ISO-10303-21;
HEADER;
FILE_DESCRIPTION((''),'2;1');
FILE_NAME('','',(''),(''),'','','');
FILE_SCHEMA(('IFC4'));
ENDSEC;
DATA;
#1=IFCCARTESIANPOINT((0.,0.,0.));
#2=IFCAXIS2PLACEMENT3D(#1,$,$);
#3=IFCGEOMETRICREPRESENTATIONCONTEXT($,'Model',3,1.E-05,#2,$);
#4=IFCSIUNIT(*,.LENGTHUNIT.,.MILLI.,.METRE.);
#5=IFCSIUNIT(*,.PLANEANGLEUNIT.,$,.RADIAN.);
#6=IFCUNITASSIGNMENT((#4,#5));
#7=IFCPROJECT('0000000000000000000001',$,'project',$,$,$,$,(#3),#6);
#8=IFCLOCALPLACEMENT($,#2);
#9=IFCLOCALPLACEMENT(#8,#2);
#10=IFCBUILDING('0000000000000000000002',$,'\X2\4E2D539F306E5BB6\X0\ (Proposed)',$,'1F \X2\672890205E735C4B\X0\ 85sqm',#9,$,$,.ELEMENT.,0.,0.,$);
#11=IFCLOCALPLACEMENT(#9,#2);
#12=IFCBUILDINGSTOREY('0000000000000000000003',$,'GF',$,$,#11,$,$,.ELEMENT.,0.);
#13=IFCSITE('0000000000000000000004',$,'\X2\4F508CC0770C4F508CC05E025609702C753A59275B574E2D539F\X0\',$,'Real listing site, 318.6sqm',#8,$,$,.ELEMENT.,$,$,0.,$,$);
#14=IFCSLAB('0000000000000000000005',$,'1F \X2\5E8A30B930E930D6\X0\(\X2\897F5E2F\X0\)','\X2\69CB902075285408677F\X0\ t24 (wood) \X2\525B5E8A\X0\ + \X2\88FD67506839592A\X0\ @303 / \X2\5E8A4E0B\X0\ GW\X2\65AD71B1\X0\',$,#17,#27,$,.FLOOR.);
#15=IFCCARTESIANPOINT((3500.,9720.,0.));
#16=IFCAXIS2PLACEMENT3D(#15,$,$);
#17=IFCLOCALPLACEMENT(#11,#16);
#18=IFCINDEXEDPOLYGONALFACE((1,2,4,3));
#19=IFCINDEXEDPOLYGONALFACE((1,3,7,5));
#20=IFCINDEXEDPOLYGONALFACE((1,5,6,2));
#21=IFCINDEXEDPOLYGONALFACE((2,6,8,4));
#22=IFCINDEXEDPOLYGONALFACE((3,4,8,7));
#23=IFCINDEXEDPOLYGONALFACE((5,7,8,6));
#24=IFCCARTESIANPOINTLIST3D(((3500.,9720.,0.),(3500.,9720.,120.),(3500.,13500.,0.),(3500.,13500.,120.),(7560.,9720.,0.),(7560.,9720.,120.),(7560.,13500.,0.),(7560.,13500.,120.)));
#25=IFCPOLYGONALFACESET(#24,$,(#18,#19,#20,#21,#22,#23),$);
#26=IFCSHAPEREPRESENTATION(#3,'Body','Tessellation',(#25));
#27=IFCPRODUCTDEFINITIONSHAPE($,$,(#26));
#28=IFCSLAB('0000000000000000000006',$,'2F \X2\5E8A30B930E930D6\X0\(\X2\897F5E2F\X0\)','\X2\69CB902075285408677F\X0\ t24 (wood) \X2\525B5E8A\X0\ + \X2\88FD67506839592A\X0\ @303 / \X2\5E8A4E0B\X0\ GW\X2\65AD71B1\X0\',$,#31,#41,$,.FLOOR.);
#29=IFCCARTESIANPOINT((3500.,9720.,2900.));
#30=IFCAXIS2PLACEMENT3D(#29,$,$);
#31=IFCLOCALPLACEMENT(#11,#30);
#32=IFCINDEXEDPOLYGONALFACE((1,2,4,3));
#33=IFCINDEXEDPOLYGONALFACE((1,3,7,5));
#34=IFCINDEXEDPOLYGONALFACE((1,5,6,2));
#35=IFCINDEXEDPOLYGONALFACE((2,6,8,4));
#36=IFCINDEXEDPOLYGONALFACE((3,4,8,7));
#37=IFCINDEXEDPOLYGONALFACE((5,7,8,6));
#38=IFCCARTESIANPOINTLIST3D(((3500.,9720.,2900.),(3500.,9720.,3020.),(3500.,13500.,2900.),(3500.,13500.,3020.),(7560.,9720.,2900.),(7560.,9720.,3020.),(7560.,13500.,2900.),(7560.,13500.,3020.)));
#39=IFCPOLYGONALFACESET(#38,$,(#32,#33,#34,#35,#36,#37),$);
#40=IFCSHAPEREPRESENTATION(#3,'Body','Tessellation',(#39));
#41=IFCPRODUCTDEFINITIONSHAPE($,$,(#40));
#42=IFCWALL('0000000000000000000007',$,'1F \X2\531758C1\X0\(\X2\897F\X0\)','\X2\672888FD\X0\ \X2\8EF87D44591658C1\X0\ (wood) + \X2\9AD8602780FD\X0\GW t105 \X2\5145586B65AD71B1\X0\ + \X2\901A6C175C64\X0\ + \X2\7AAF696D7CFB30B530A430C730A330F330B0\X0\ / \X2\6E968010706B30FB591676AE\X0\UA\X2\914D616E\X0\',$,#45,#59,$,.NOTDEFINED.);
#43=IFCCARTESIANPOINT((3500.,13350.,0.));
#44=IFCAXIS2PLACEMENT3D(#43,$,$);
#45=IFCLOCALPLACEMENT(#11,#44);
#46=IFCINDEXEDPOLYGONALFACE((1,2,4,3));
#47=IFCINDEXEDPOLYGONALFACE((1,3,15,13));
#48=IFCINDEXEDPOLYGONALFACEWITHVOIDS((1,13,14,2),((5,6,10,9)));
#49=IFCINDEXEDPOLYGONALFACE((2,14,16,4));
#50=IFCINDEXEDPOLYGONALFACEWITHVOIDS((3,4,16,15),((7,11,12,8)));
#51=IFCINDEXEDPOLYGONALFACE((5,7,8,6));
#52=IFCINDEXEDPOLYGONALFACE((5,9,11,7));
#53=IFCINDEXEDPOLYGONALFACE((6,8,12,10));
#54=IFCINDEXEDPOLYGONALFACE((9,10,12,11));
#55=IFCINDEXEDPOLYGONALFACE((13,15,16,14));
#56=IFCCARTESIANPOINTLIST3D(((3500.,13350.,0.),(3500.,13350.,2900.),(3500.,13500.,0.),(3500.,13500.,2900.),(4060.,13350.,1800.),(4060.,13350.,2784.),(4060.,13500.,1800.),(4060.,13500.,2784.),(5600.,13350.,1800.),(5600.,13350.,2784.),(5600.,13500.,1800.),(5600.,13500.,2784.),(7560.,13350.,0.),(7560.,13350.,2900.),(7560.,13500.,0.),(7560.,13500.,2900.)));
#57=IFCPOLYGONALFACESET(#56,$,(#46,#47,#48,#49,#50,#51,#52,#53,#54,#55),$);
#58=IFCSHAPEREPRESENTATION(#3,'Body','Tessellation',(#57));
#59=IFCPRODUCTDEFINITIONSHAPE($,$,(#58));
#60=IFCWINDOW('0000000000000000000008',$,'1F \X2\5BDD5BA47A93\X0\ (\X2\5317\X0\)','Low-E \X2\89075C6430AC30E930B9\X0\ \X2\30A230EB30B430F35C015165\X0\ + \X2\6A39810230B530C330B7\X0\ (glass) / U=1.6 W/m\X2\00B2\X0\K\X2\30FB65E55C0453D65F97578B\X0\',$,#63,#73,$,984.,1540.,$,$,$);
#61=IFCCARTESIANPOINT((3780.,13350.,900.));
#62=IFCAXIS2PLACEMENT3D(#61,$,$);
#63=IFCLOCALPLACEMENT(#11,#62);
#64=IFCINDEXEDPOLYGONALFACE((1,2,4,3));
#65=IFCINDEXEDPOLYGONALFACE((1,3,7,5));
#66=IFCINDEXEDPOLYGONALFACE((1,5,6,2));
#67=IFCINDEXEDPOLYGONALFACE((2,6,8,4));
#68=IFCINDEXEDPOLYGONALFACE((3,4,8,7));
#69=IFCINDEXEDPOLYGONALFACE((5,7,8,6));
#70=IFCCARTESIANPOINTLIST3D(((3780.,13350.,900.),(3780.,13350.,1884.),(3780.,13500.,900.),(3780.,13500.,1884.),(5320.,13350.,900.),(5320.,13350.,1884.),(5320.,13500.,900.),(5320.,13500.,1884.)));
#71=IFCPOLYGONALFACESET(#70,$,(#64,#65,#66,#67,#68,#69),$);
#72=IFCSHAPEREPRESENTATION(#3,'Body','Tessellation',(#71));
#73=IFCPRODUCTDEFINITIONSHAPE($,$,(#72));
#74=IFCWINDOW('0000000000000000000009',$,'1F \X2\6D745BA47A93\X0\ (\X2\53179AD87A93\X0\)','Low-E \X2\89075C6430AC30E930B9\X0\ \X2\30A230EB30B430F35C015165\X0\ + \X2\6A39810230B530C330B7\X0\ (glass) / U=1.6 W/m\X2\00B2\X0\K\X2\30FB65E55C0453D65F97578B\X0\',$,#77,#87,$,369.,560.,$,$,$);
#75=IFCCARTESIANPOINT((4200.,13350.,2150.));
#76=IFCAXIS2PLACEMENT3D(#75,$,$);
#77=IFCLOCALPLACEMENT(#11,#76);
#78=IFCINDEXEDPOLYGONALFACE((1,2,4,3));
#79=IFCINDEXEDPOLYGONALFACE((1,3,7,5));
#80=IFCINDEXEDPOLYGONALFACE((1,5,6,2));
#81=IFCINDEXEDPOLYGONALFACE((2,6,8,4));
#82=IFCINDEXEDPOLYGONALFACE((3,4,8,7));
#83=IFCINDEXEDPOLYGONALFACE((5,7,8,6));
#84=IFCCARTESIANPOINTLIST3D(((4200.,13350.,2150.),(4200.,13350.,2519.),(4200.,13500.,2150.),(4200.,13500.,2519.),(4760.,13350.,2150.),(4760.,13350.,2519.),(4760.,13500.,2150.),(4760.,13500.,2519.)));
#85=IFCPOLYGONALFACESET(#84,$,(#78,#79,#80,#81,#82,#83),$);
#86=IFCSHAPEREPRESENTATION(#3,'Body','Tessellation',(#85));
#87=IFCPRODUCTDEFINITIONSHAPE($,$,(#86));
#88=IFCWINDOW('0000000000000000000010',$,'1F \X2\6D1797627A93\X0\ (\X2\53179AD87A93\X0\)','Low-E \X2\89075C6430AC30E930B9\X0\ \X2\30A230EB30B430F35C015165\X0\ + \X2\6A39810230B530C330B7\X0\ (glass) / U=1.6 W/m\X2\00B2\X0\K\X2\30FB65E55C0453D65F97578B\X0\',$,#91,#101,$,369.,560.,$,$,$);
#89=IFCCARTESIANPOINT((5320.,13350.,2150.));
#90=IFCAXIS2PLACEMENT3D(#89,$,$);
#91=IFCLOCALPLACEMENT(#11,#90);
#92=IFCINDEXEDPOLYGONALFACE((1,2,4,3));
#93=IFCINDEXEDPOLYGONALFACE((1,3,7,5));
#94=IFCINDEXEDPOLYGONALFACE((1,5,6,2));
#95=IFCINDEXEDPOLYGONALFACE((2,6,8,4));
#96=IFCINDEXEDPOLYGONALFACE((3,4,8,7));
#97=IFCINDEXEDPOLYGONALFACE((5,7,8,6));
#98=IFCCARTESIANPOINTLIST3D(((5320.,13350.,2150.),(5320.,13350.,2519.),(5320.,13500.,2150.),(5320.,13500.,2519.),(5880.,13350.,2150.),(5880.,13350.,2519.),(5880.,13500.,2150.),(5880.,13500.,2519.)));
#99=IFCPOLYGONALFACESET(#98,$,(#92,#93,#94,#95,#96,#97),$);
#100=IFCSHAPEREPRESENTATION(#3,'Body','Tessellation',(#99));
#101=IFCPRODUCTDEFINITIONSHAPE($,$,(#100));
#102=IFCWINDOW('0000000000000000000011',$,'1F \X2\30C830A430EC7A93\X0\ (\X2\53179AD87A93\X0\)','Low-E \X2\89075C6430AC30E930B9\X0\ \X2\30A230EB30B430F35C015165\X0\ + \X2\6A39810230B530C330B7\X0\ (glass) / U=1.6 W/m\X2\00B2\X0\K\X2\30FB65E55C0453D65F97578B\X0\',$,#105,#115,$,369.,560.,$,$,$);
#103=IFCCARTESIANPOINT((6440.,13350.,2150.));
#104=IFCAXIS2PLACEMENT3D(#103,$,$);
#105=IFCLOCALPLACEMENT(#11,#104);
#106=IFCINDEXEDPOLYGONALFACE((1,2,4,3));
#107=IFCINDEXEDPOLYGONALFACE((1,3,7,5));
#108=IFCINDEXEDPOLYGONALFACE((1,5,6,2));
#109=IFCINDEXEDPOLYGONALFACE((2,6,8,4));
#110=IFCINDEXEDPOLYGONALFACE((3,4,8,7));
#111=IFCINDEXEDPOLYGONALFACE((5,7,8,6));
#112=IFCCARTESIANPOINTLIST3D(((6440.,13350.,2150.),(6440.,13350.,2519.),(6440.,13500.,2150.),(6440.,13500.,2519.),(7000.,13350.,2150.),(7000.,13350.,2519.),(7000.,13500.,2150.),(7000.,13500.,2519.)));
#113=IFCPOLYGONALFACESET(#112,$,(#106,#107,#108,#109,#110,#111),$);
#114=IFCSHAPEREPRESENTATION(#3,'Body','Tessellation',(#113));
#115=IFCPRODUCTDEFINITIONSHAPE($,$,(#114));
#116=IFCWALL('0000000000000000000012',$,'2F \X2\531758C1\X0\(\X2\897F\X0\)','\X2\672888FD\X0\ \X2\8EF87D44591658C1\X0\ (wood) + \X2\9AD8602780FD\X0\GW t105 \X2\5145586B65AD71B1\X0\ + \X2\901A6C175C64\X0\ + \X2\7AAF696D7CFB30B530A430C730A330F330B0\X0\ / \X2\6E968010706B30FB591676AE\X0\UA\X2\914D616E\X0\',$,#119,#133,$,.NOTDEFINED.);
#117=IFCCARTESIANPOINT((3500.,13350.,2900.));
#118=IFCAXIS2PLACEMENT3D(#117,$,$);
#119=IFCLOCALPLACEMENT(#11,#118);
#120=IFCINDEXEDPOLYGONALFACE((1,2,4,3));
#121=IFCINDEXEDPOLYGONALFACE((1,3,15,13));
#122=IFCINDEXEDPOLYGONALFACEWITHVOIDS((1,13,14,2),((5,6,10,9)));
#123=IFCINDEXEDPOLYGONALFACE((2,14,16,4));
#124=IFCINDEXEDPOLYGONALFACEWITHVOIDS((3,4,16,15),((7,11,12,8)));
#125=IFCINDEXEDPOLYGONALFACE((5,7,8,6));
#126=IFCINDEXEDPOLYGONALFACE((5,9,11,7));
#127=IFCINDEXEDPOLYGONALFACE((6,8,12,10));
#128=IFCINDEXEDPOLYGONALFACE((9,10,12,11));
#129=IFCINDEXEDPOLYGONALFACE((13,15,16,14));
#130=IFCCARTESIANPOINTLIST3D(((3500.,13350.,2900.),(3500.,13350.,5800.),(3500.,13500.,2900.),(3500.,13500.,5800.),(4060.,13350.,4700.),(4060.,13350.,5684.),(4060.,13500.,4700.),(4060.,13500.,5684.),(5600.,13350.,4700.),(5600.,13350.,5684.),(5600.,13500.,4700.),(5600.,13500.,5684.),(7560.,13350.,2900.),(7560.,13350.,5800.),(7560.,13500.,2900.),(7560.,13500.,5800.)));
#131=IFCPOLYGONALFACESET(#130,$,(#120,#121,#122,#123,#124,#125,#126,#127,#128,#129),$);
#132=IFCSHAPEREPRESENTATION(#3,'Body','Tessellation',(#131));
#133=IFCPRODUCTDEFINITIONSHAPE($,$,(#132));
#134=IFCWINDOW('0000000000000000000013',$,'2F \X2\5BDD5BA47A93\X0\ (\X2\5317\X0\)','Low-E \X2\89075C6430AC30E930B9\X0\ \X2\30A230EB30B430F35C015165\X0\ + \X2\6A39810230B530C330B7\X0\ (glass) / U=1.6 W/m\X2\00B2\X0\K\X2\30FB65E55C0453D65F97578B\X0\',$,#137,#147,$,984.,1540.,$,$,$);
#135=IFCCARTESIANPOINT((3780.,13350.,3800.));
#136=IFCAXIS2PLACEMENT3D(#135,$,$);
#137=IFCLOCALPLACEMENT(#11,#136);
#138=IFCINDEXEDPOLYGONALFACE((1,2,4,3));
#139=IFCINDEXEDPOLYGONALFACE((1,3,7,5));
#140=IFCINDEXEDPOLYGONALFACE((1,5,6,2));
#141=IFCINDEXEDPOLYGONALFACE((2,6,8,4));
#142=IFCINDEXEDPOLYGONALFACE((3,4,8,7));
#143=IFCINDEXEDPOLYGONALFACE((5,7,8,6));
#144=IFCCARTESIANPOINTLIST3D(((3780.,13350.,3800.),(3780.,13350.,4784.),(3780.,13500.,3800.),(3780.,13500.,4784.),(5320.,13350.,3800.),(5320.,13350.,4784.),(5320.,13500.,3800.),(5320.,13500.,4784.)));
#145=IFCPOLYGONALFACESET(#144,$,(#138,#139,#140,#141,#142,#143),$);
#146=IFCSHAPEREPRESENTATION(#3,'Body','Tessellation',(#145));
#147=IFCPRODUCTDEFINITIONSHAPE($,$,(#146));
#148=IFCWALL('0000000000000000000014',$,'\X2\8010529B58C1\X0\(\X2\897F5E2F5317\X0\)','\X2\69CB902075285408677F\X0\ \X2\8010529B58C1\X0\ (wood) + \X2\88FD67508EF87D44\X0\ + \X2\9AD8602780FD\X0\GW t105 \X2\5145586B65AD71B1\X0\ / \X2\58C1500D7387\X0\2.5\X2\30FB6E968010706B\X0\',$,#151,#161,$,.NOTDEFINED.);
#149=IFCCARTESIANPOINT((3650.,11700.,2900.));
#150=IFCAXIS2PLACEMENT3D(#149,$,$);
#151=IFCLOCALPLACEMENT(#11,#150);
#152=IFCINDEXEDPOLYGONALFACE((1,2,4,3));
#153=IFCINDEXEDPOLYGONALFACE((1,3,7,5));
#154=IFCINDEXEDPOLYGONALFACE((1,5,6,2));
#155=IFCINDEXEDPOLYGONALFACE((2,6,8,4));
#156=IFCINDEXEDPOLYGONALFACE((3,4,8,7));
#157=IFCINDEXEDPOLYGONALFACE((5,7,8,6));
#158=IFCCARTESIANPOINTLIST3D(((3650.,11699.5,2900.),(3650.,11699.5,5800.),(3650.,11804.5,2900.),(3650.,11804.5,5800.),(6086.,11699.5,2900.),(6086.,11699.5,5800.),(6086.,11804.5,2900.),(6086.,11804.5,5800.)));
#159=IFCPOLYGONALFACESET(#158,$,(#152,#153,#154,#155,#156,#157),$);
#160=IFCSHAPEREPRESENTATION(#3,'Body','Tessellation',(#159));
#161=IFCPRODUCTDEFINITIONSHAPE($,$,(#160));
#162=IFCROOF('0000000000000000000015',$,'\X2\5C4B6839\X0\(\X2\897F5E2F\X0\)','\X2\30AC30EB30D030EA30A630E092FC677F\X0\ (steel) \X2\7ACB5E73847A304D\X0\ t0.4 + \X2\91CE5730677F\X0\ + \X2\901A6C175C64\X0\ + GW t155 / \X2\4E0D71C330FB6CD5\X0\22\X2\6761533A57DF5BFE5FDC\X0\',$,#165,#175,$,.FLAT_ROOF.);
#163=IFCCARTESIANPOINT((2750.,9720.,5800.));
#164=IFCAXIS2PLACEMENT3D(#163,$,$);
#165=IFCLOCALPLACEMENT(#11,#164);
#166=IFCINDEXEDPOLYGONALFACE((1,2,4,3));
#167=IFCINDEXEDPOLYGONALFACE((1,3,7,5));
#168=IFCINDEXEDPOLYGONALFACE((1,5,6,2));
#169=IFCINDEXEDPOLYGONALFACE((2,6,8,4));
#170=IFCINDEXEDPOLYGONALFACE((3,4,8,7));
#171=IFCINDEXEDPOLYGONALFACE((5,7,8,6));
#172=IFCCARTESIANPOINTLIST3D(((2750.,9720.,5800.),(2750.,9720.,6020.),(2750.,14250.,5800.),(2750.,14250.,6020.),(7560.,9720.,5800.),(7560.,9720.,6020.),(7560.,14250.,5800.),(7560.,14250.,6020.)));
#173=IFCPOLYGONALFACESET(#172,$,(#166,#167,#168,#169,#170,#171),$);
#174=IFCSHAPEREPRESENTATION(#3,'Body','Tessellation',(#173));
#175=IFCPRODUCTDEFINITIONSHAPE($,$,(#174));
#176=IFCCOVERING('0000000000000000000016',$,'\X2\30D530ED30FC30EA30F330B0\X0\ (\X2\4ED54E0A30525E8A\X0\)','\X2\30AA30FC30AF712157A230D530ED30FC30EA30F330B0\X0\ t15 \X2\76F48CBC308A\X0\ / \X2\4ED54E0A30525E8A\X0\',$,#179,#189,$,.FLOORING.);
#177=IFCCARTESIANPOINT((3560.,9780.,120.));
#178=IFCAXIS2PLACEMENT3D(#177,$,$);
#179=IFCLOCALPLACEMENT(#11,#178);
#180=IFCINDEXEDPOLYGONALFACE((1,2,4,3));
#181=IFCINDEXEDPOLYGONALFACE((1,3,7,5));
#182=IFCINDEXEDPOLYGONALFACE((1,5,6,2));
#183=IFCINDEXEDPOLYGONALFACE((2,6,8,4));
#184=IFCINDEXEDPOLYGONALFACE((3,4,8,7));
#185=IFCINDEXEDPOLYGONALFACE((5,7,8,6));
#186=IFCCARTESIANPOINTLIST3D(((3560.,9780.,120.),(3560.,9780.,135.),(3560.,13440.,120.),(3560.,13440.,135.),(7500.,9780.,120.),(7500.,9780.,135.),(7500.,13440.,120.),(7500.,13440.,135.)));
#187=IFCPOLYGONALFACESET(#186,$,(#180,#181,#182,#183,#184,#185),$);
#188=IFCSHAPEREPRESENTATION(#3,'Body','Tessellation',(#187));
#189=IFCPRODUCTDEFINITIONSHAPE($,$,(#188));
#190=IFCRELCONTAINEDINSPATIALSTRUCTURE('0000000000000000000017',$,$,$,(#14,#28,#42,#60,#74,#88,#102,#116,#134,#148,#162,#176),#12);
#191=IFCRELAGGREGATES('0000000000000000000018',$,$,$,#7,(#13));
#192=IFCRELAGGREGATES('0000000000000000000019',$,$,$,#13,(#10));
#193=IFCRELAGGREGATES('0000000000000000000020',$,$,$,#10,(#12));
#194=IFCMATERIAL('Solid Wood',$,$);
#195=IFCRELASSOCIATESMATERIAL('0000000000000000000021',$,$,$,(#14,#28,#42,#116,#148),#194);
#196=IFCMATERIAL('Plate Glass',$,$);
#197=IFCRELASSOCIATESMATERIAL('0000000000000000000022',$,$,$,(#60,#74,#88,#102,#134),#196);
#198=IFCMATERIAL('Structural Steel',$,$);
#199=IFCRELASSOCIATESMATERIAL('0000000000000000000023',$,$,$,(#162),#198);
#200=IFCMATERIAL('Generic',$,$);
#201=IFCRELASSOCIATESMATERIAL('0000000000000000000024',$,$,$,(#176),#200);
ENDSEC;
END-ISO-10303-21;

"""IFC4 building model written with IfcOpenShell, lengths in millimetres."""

from ifc_helpers import new_model, si_unit, frame, frame_2d, origin, place, context, project, spatial, rectangle, extrude, material, element, fill, save


model = new_model("IFC4")

# Units and contexts
model_context = context("Model", 3, precision=1e-05, world=origin())
ifc_project = project(units=[si_unit("LENGTHUNIT", "METRE", prefix="MILLI"), si_unit("PLANEANGLEUNIT", "RADIAN")], contexts=[model_context])

# Site, building, storey
site_placement = place(None, origin())
site = spatial("IfcSite", under=ifc_project, at=site_placement, Name="佐賀県佐賀市嘉瀬町大字中原", ObjectType="Real listing site, 318.6sqm", CompositionType="ELEMENT", RefElevation=0.0)
building_placement = place(site_placement, origin())
building = spatial("IfcBuilding", under=site, at=building_placement, Name="中原の家 (Proposed)", ObjectType="1F 木造平屋 85sqm", CompositionType="ELEMENT", ElevationOfRefHeight=0.0, ElevationOfTerrain=0.0)
storey_placement = place(building_placement, origin())
storey = spatial("IfcBuildingStorey", under=building, at=storey_placement, Name="GF", CompositionType="ELEMENT", Elevation=0.0)

# Slabs
ifc_material_1 = material(Name="Solid Wood")
slab_1_placement = place(storey_placement, frame((3500.0, 9720.0, 0.0)))
element("IfcSlab", 1, at=slab_1_placement, inside=storey, material=ifc_material_1, Name="1F 床スラブ(西帯)", Description="構造用合板 t24 (wood) 剛床 + 製材根太 @303 / 床下 GW断熱", PredefinedType="FLOOR", context=model_context, shape_type="SweptSolid", body=[
    extrude(rectangle(XDim=4060.0, YDim=3780.0, at=frame_2d((2030.0, 1890.0))), frame((3500.0, 9720.0, 0.0)), (0.0, 0.0, 1.0), 120.0),
])
slab_2_placement = place(storey_placement, frame((3500.0, 9720.0, 2900.0)))
element("IfcSlab", 2, at=slab_2_placement, inside=storey, material=ifc_material_1, Name="2F 床スラブ(西帯)", Description="構造用合板 t24 (wood) 剛床 + 製材根太 @303 / 床下 GW断熱", PredefinedType="FLOOR", context=model_context, shape_type="SweptSolid", body=[
    extrude(rectangle(XDim=4060.0, YDim=3780.0, at=frame_2d((2030.0, 1890.0))), frame((3500.0, 9720.0, 2900.0)), (0.0, 0.0, 1.0), 120.0),
])

# Wall, openings, windows
wall_1_placement = place(storey_placement, frame((3500.0, 13350.0, 0.0)))
wall_1 = element("IfcWall", 3, at=wall_1_placement, inside=storey, material=ifc_material_1, Name="1F 北壁(西)", Description="木製 軸組外壁 (wood) + 高性能GW t105 充填断熱 + 通気層 + 窯業系サイディング / 準耐火・外皮UA配慮", PredefinedType="NOTDEFINED", context=model_context, shape_type="SweptSolid", body=[
    extrude(rectangle(XDim=4060.0, YDim=150.0, at=frame_2d((2030.0, 75.0))), frame((3500.0, 13350.0, 0.0)), (0.0, 0.0, 1.0), 2900.0),
])
opening_1_placement = place(storey_placement, frame((3780.0, 13350.0, 900.0)))
opening_1 = element("IfcOpeningElement", 4, at=opening_1_placement, cuts=wall_1, PredefinedType="NOTDEFINED", context=model_context, shape_type="SweptSolid", body=[
    extrude(rectangle(XDim=1540.0, YDim=150.0, at=frame_2d((770.0, 75.0))), frame((3780.0, 13350.0, 900.0)), (0.0, 0.0, 1.0), 984.0),
])
opening_2_placement = place(storey_placement, frame((4200.0, 13350.0, 2150.0)))
opening_2 = element("IfcOpeningElement", 5, at=opening_2_placement, cuts=wall_1, PredefinedType="NOTDEFINED", context=model_context, shape_type="SweptSolid", body=[
    extrude(rectangle(XDim=560.0, YDim=150.0, at=frame_2d((280.0, 75.0))), frame((4200.0, 13350.0, 2150.0)), (0.0, 0.0, 1.0), 369.0),
])
opening_3_placement = place(storey_placement, frame((5320.0, 13350.0, 2150.0)))
opening_3 = element("IfcOpeningElement", 6, at=opening_3_placement, cuts=wall_1, PredefinedType="NOTDEFINED", context=model_context, shape_type="SweptSolid", body=[
    extrude(rectangle(XDim=560.0, YDim=150.0, at=frame_2d((280.0, 75.0))), frame((5320.0, 13350.0, 2150.0)), (0.0, 0.0, 1.0), 369.0),
])
opening_4_placement = place(storey_placement, frame((6440.0, 13350.0, 2150.0)))
opening_4 = element("IfcOpeningElement", 7, at=opening_4_placement, cuts=wall_1, PredefinedType="NOTDEFINED", context=model_context, shape_type="SweptSolid", body=[
    extrude(rectangle(XDim=560.0, YDim=150.0, at=frame_2d((280.0, 75.0))), frame((6440.0, 13350.0, 2150.0)), (0.0, 0.0, 1.0), 369.0),
])
ifc_material_2 = material(Name="Plate Glass")
window_1_placement = place(storey_placement, frame((3780.0, 13350.0, 900.0)))
window_1 = element("IfcWindow", 8, at=window_1_placement, inside=storey, material=ifc_material_2, Name="1F 寝室窓 (北)", Description="Low-E 複層ガラス アルゴン封入 + 樹脂サッシ (glass) / U=1.6 W/m²K・日射取得型", OverallHeight=984.0, OverallWidth=1540.0, context=model_context, shape_type="SweptSolid", body=[
    extrude(rectangle(XDim=1540.0, YDim=150.0, at=frame_2d((770.0, 75.0))), frame((3780.0, 13350.0, 900.0)), (0.0, 0.0, 1.0), 984.0),
])
fill(opening_1, window_1)
window_2_placement = place(storey_placement, frame((4200.0, 13350.0, 2150.0)))
window_2 = element("IfcWindow", 9, at=window_2_placement, inside=storey, material=ifc_material_2, Name="1F 浴室窓 (北高窓)", Description="Low-E 複層ガラス アルゴン封入 + 樹脂サッシ (glass) / U=1.6 W/m²K・日射取得型", OverallHeight=369.0, OverallWidth=560.0, context=model_context, shape_type="SweptSolid", body=[
    extrude(rectangle(XDim=560.0, YDim=150.0, at=frame_2d((280.0, 75.0))), frame((4200.0, 13350.0, 2150.0)), (0.0, 0.0, 1.0), 369.0),
])
fill(opening_2, window_2)
window_3_placement = place(storey_placement, frame((5320.0, 13350.0, 2150.0)))
window_3 = element("IfcWindow", 10, at=window_3_placement, inside=storey, material=ifc_material_2, Name="1F 洗面窓 (北高窓)", Description="Low-E 複層ガラス アルゴン封入 + 樹脂サッシ (glass) / U=1.6 W/m²K・日射取得型", OverallHeight=369.0, OverallWidth=560.0, context=model_context, shape_type="SweptSolid", body=[
    extrude(rectangle(XDim=560.0, YDim=150.0, at=frame_2d((280.0, 75.0))), frame((5320.0, 13350.0, 2150.0)), (0.0, 0.0, 1.0), 369.0),
])
fill(opening_3, window_3)
window_4_placement = place(storey_placement, frame((6440.0, 13350.0, 2150.0)))
window_4 = element("IfcWindow", 11, at=window_4_placement, inside=storey, material=ifc_material_2, Name="1F トイレ窓 (北高窓)", Description="Low-E 複層ガラス アルゴン封入 + 樹脂サッシ (glass) / U=1.6 W/m²K・日射取得型", OverallHeight=369.0, OverallWidth=560.0, context=model_context, shape_type="SweptSolid", body=[
    extrude(rectangle(XDim=560.0, YDim=150.0, at=frame_2d((280.0, 75.0))), frame((6440.0, 13350.0, 2150.0)), (0.0, 0.0, 1.0), 369.0),
])
fill(opening_4, window_4)

# Wall, opening, window
wall_2_placement = place(storey_placement, frame((3500.0, 13350.0, 2900.0)))
wall_2 = element("IfcWall", 12, at=wall_2_placement, inside=storey, material=ifc_material_1, Name="2F 北壁(西)", Description="木製 軸組外壁 (wood) + 高性能GW t105 充填断熱 + 通気層 + 窯業系サイディング / 準耐火・外皮UA配慮", PredefinedType="NOTDEFINED", context=model_context, shape_type="SweptSolid", body=[
    extrude(rectangle(XDim=4060.0, YDim=150.0, at=frame_2d((2030.0, 75.0))), frame((3500.0, 13350.0, 2900.0)), (0.0, 0.0, 1.0), 2900.0),
])
opening_5_placement = place(storey_placement, frame((3780.0, 13350.0, 3800.0)))
opening_5 = element("IfcOpeningElement", 13, at=opening_5_placement, cuts=wall_2, PredefinedType="NOTDEFINED", context=model_context, shape_type="SweptSolid", body=[
    extrude(rectangle(XDim=1540.0, YDim=150.0, at=frame_2d((770.0, 75.0))), frame((3780.0, 13350.0, 3800.0)), (0.0, 0.0, 1.0), 984.0),
])
window_5_placement = place(storey_placement, frame((3780.0, 13350.0, 3800.0)))
window_5 = element("IfcWindow", 14, at=window_5_placement, inside=storey, material=ifc_material_2, Name="2F 寝室窓 (北)", Description="Low-E 複層ガラス アルゴン封入 + 樹脂サッシ (glass) / U=1.6 W/m²K・日射取得型", OverallHeight=984.0, OverallWidth=1540.0, context=model_context, shape_type="SweptSolid", body=[
    extrude(rectangle(XDim=1540.0, YDim=150.0, at=frame_2d((770.0, 75.0))), frame((3780.0, 13350.0, 3800.0)), (0.0, 0.0, 1.0), 984.0),
])
fill(opening_5, window_5)

# Wall
wall_3_placement = place(storey_placement, frame((3650.0, 11700.0, 2900.0)))
element("IfcWall", 15, at=wall_3_placement, inside=storey, material=ifc_material_1, Name="耐力壁(西帯北)", Description="構造用合板 耐力壁 (wood) + 製材軸組 + 高性能GW t105 充填断熱 / 壁倍率2.5・準耐火", PredefinedType="NOTDEFINED", context=model_context, shape_type="SweptSolid", body=[
    extrude(rectangle(XDim=2436.0, YDim=105.0, at=frame_2d((1218.0, 52.0))), frame((3650.0, 11700.0, 2900.0)), (0.0, 0.0, 1.0), 2900.0),
])

# Roof
ifc_material_3 = material(Name="Structural Steel")
for number, where, name in (
    (16, (2750.0, 9720.0, 5800.0), "屋根(西帯)"),
):
    element("IfcRoof", number, at=place(storey_placement, frame(where)), inside=storey, material=ifc_material_3, Name=name, Description="ガルバリウム鋼板 (steel) 立平葺き t0.4 + 野地板 + 通気層 + GW t155 / 不燃・法22条区域対応", PredefinedType="FLAT_ROOF", context=model_context, shape_type="SweptSolid", body=[
        extrude(rectangle(XDim=4810.0, YDim=4530.0, at=frame_2d((2405.0, 2265.0))), frame((2750.0, 9720.0, 5800.0)), (0.0, 0.0, 1.0), 220.0),
    ])

# Covering
ifc_material_4 = material(Name="Generic")
covering_1_placement = place(storey_placement, frame((3560.0, 9780.0, 120.0)))
element("IfcCovering", 17, at=covering_1_placement, inside=storey, material=ifc_material_4, Name="フローリング (仕上げ床)", Description="オーク無垢フローリング t15 直貼り / 仕上げ床", PredefinedType="FLOORING", context=model_context, shape_type="SweptSolid", body=[
    extrude(rectangle(XDim=3940.0, YDim=3660.0, at=frame_2d((1970.0, 1830.0))), frame((3560.0, 9780.0, 120.0)), (0.0, 0.0, 1.0), 15.0),
])

save(model, "model.ifc")
